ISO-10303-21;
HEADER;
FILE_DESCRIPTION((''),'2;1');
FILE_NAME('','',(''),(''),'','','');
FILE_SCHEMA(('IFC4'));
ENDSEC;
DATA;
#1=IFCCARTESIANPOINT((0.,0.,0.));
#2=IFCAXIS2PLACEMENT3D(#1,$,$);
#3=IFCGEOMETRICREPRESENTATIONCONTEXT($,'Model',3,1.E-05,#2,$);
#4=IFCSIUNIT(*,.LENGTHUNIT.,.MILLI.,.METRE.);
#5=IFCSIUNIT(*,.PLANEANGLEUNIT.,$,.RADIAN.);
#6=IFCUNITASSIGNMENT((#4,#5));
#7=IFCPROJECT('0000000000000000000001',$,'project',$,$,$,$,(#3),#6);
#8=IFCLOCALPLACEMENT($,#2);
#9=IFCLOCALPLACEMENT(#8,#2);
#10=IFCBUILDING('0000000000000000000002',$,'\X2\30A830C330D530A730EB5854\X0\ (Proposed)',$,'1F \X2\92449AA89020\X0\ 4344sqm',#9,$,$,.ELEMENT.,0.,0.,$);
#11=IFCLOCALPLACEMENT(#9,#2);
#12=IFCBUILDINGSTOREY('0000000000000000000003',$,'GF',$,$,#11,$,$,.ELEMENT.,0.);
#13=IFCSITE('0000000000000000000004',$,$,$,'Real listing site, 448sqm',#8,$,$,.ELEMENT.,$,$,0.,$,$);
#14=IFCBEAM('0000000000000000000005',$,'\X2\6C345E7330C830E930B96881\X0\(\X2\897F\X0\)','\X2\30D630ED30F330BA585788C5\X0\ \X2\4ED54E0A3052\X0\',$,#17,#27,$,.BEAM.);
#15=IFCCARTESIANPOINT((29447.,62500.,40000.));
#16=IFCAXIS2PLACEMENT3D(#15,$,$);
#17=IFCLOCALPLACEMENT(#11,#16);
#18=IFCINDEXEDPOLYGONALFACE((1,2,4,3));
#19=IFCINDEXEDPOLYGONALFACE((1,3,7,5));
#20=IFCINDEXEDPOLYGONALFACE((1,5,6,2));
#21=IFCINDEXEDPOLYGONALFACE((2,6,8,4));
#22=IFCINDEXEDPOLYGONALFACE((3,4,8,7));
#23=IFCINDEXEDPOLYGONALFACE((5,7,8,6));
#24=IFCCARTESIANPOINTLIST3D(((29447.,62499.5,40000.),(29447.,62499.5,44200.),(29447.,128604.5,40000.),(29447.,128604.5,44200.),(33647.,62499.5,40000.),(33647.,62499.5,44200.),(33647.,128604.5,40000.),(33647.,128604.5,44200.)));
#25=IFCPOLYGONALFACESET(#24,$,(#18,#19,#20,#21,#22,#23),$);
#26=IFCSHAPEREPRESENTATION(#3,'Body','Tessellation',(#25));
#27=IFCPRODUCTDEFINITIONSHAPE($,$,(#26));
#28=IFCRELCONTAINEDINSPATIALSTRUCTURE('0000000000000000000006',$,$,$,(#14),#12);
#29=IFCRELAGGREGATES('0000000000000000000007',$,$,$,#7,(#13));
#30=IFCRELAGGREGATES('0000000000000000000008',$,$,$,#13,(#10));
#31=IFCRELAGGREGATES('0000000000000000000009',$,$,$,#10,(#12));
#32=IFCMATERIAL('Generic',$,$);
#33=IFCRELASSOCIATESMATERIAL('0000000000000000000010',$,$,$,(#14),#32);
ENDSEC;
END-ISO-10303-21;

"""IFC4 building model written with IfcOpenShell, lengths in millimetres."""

from ifc_helpers import new_model, si_unit, frame, frame_2d, origin, place, context, project, spatial, rectangle, extrude, material, element, save


model = new_model("IFC4")

# Units and contexts
model_context = context("Model", 3, precision=1e-05, world=origin())
ifc_project = project(units=[si_unit("LENGTHUNIT", "METRE", prefix="MILLI"), si_unit("PLANEANGLEUNIT", "RADIAN")], contexts=[model_context])

# Site, building, storey
site_placement = place(None, origin())
site = spatial("IfcSite", under=ifc_project, at=site_placement, ObjectType="Real listing site, 448sqm", CompositionType="ELEMENT", RefElevation=0.0)
building_placement = place(site_placement, origin())
building = spatial("IfcBuilding", under=site, at=building_placement, Name="エッフェル塔 (Proposed)", ObjectType="1F 鉄骨造 4344sqm", CompositionType="ELEMENT", ElevationOfRefHeight=0.0, ElevationOfTerrain=0.0)
storey_placement = place(building_placement, origin())
storey = spatial("IfcBuildingStorey", under=building, at=storey_placement, Name="GF", CompositionType="ELEMENT", Elevation=0.0)

# Shared definitions
ifc_material = material(Name="Generic")

# Beam
beam_1_placement = place(storey_placement, frame((29447.0, 62500.0, 40000.0)))
element("IfcBeam", 1, at=beam_1_placement, inside=storey, material=ifc_material, Name="水平トラス梁(西)", Description="ブロンズ塗装 仕上げ", PredefinedType="BEAM", context=model_context, shape_type="SweptSolid", body=[
    extrude(rectangle(XDim=4200.0, YDim=66105.0, at=frame_2d((2100.0, 33052.0))), frame((29447.0, 62500.0, 40000.0)), (0.0, 0.0, 1.0), 4200.0),
])

save(model, "model.ifc")
